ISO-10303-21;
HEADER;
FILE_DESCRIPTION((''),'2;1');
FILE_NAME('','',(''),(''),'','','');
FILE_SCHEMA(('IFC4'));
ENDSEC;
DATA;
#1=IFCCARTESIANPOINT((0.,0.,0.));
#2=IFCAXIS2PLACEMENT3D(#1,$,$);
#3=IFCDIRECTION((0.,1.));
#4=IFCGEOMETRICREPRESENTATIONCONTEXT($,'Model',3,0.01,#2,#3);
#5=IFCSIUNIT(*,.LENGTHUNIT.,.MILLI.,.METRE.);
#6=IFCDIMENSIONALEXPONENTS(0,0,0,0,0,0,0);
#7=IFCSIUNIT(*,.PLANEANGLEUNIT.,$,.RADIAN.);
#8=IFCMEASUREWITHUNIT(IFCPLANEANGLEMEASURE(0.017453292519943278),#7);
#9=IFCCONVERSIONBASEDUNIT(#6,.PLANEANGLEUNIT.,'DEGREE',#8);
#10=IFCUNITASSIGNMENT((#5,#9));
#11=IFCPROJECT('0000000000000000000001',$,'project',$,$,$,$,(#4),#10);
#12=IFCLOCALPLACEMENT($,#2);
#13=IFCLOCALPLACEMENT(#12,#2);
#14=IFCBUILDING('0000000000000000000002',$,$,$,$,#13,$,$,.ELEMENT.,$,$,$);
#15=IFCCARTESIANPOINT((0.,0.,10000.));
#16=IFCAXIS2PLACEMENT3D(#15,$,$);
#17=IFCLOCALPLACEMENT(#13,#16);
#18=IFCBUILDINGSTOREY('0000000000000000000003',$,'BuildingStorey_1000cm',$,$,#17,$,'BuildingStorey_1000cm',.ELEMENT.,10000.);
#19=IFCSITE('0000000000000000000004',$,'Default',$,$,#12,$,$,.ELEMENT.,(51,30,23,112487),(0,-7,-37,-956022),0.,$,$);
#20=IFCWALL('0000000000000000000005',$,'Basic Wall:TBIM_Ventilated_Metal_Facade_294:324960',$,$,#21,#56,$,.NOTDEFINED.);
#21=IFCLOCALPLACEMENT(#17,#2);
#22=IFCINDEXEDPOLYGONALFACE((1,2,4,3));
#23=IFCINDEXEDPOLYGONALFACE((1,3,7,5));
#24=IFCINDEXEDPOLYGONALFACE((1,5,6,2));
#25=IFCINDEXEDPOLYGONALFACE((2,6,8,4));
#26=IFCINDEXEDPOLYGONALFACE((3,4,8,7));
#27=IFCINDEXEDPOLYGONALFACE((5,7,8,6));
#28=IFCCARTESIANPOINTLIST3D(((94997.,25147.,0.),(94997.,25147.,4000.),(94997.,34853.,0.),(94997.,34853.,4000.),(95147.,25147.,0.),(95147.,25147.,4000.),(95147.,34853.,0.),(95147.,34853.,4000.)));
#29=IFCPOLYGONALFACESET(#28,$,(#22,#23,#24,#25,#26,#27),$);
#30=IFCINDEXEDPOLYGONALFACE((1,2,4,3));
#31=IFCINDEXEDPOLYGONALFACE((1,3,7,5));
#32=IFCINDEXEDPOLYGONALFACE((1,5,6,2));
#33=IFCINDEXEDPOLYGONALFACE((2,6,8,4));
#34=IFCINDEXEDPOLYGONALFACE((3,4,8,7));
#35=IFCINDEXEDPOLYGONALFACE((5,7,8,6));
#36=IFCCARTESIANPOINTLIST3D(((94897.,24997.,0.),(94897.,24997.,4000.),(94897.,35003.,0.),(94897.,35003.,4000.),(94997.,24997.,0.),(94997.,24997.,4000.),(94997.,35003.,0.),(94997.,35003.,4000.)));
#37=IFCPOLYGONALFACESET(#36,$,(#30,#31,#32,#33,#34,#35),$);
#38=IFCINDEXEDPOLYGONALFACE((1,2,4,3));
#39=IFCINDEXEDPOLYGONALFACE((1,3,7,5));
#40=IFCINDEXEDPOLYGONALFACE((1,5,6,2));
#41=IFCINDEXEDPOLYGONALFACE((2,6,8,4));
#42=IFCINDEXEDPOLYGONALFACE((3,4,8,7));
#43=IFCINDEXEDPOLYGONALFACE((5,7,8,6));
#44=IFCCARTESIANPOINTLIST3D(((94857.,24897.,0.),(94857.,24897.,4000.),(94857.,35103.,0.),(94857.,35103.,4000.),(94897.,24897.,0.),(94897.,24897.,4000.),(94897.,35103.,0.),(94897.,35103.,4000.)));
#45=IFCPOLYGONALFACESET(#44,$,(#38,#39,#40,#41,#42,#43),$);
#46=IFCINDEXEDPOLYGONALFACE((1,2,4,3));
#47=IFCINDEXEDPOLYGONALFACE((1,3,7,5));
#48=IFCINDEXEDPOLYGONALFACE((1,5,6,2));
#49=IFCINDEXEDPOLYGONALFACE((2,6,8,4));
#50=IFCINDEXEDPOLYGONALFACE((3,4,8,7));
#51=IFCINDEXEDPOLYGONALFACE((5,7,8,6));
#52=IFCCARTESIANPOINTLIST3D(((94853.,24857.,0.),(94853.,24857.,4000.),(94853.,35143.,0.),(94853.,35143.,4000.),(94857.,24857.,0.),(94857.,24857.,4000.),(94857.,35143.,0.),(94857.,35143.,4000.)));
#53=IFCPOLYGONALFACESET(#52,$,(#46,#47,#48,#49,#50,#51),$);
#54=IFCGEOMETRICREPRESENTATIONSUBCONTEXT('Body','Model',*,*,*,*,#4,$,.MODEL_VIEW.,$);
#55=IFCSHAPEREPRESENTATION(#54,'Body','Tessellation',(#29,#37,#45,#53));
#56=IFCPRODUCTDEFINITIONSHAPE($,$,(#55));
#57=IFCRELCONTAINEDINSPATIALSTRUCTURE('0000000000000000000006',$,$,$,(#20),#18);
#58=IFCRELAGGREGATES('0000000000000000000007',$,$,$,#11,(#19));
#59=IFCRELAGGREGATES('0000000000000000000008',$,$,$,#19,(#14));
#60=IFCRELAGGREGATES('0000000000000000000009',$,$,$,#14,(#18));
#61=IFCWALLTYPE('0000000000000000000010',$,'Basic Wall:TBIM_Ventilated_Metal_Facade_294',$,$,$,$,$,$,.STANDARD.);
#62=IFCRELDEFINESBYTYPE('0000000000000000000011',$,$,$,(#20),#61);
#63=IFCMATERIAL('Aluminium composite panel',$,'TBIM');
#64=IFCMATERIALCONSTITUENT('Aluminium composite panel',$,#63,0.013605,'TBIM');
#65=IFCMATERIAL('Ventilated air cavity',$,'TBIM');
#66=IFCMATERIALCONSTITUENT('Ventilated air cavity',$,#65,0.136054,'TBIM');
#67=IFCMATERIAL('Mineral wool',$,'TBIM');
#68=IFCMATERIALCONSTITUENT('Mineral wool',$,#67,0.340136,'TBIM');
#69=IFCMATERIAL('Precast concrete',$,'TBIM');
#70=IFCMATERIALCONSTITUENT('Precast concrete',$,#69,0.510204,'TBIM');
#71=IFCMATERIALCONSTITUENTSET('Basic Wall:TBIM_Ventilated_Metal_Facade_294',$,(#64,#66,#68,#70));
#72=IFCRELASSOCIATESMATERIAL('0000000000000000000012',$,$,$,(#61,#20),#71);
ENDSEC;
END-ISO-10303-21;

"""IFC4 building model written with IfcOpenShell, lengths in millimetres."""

from ifc_helpers import new_model, entity, si_unit, converted_unit, direction, frame, origin, place, context, subcontext, project, spatial, indexed_curve, outline, extrude, material, constituent, constituent_set, type_object, element, save


model = new_model("IFC4")

# Units and contexts
model_context = context("Model", 3, precision=0.01, world=origin(), true_north=direction((0.0, 1.0)))
body_context = subcontext(model_context, "Body", "Model", "MODEL_VIEW")
ifc_project = project(units=[si_unit("LENGTHUNIT", "METRE", prefix="MILLI"), converted_unit("PLANEANGLEUNIT", "DEGREE", entity("IfcPlaneAngleMeasure", 0.017453292519943278), si_unit("PLANEANGLEUNIT", "RADIAN"), dimensions=[0, 0, 0, 0, 0, 0, 0])], contexts=[model_context])

# Site, building, storey
site_placement = place(None, origin())
site = spatial("IfcSite", under=ifc_project, at=site_placement, Name="Default", CompositionType="ELEMENT", RefLatitude=(51, 30, 23, 112487), RefLongitude=(0, -7, -37, -956022), RefElevation=0.0)
building_placement = place(site_placement, origin())
building = spatial("IfcBuilding", under=site, at=building_placement, CompositionType="ELEMENT")
storey_placement = place(building_placement, frame((0.0, 0.0, 10000.0)))
storey = spatial("IfcBuildingStorey", under=building, at=storey_placement, Name="BuildingStorey_1000cm", LongName="BuildingStorey_1000cm", CompositionType="ELEMENT", Elevation=10000.0)

# Shared definitions
ifc_material_1 = material(Name="Mineral wool", Category="TBIM")

# Wall
ifc_material_2 = material(Name="Aluminium composite panel", Category="TBIM")
ifc_constituent_1 = constituent(ifc_material_2, Name="Aluminium composite panel", Category="TBIM", fraction=0.013605)
ifc_material_3 = material(Name="Ventilated air cavity", Category="TBIM")
ifc_constituent_2 = constituent(ifc_material_3, Name="Ventilated air cavity", Category="TBIM", fraction=0.136054)
ifc_constituent_3 = constituent(ifc_material_1, Name="Mineral wool", Category="TBIM", fraction=0.340136)
ifc_material_4 = material(Name="Precast concrete", Category="TBIM")
ifc_constituent_4 = constituent(ifc_material_4, Name="Precast concrete", Category="TBIM", fraction=0.510204)
ifc_constituent_set_1 = constituent_set(constituents=[ifc_constituent_1, ifc_constituent_2, ifc_constituent_3, ifc_constituent_4], Name="Basic Wall:TBIM_Ventilated_Metal_Facade_294")
wall_type = type_object("IfcWallType", Name="Basic Wall:TBIM_Ventilated_Metal_Facade_294", PredefinedType="STANDARD", material=ifc_constituent_set_1)
wall_1_placement = place(storey_placement, frame((95000.0, 25147.0, 0.0), z_axis=(0.0, 0.0, 1.0), x_axis=(0.0, 1.0, 0.0)))
element("IfcWall", 1, at=wall_1_placement, inside=storey, type_object=wall_type, material=ifc_constituent_set_1, Name="Basic Wall:TBIM_Ventilated_Metal_Facade_294:324960", PredefinedType="NOTDEFINED", context=body_context, shape_type="SweptSolid", body=[
    extrude(outline(indexed_curve([(-75.0, -4853.0), (75.0, -4853.0), (75.0, 4853.0), (-75.0, 4853.0), (-75.0, -4853.0)], self_intersect=False)), frame((4853.0, -72.0, 0.0), z_axis=(0.0, 0.0, 1.0), x_axis=(0.0, 1.0, 0.0)), (0.0, 0.0, 1.0), 4000.0),
    extrude(outline(indexed_curve([(-5003.0, -50.0), (5003.0, -50.0), (5003.0, 50.0), (-5003.0, 50.0), (-5003.0, -50.0)], self_intersect=False)), frame((4853.0, 53.0, 0.0)), (0.0, 0.0, 1.0), 4000.0),
    extrude(outline(indexed_curve([(-5103.0, -20.0), (5103.0, -20.0), (5103.0, 20.0), (-5103.0, 20.0), (-5103.0, -20.0)], self_intersect=False)), frame((4853.0, 123.0, 0.0)), (0.0, 0.0, 1.0), 4000.0),
    extrude(outline(indexed_curve([(-2.0, -5143.0), (2.0, -5143.0), (2.0, 5143.0), (-2.0, 5143.0), (-2.0, -5143.0)], self_intersect=False)), frame((4853.0, 145.0, 0.0), z_axis=(0.0, 0.0, 1.0), x_axis=(0.0, -1.0, 0.0)), (0.0, 0.0, 1.0), 4000.0),
])

save(model, "model.ifc")
